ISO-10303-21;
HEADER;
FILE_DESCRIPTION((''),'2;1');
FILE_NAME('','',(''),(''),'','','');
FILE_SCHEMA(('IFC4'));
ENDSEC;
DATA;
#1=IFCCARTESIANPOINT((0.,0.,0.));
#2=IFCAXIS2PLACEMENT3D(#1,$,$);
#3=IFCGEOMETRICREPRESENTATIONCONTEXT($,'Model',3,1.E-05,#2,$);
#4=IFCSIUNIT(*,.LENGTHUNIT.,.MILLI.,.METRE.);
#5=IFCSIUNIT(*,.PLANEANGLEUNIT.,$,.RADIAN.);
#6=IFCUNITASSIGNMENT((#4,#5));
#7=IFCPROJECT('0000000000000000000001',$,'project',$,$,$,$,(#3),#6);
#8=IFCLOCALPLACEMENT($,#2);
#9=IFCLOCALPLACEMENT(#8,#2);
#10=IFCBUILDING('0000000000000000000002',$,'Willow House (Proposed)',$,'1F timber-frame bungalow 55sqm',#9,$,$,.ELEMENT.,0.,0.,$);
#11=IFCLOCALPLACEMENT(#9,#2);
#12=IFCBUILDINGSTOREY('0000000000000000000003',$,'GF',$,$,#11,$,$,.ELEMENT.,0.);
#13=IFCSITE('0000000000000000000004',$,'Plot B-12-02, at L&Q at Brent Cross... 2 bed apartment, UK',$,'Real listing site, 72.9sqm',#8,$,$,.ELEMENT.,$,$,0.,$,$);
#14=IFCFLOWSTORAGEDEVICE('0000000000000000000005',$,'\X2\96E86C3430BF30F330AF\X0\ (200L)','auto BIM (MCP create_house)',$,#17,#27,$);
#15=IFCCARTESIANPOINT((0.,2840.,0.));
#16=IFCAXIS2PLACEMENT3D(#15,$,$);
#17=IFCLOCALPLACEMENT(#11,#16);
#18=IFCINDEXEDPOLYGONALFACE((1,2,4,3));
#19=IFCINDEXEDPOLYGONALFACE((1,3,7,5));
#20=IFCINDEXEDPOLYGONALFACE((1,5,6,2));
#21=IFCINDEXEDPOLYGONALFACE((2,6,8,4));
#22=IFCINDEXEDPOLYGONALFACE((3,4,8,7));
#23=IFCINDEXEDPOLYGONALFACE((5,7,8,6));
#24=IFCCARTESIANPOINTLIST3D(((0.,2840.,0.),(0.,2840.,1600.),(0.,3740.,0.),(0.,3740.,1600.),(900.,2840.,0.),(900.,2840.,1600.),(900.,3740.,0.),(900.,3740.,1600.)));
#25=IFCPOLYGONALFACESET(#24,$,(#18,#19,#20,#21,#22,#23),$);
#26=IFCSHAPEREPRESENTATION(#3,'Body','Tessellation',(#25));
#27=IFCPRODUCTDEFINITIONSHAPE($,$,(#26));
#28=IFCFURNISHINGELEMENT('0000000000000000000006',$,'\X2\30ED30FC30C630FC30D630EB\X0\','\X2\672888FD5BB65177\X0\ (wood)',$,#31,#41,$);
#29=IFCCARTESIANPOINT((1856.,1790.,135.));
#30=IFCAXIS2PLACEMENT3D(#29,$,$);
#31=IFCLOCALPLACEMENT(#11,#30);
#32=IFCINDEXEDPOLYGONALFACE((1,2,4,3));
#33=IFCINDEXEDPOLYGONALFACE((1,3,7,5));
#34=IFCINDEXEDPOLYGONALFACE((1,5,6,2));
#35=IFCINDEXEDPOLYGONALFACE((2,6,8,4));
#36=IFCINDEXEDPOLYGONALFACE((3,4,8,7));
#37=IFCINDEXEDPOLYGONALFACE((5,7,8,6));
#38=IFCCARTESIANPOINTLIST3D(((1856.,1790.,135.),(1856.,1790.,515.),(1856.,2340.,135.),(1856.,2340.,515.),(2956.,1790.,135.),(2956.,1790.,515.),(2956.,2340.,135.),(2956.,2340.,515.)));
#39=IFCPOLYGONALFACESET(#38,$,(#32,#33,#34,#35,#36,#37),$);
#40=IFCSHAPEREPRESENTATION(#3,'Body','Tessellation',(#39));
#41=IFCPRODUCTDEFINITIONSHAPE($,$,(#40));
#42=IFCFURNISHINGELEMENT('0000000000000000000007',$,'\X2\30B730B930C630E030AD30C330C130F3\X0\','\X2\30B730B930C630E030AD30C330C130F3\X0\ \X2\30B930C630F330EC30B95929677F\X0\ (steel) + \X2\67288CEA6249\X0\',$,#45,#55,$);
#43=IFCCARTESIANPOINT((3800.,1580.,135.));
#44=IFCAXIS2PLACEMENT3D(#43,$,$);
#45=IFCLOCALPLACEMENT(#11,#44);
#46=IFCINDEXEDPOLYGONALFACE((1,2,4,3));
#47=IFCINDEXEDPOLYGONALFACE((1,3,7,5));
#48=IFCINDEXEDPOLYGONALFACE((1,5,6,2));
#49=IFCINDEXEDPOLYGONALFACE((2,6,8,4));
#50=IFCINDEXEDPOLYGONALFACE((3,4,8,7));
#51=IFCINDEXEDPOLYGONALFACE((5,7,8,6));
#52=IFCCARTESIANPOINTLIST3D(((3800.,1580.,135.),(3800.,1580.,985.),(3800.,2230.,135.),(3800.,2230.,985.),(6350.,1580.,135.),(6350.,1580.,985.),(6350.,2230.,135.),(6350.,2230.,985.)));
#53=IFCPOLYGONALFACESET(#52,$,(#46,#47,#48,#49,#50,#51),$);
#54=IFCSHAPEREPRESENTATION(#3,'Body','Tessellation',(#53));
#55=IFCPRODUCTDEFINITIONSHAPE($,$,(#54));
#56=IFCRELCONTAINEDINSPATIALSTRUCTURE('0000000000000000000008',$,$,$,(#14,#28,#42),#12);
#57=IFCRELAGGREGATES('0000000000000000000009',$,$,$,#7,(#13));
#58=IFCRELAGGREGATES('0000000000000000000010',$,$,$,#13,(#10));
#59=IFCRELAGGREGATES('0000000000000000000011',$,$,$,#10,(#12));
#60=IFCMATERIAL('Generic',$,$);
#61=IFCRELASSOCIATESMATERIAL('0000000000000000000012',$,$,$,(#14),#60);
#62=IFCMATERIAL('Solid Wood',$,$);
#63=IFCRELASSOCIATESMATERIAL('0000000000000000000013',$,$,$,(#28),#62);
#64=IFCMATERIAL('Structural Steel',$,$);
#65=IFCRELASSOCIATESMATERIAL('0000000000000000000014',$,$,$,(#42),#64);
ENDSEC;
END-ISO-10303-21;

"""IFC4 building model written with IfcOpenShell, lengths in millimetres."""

from ifc_helpers import new_model, si_unit, frame, frame_2d, origin, place, context, project, spatial, rectangle, extrude, material, element, save


model = new_model("IFC4")

# Units and contexts
model_context = context("Model", 3, precision=1e-05, world=origin())
ifc_project = project(units=[si_unit("LENGTHUNIT", "METRE", prefix="MILLI"), si_unit("PLANEANGLEUNIT", "RADIAN")], contexts=[model_context])

# Site, building, storey
site_placement = place(None, origin())
site = spatial("IfcSite", under=ifc_project, at=site_placement, Name="Plot B-12-02, at L&Q at Brent Cross... 2 bed apartment, UK", ObjectType="Real listing site, 72.9sqm", CompositionType="ELEMENT", RefElevation=0.0)
building_placement = place(site_placement, origin())
building = spatial("IfcBuilding", under=site, at=building_placement, Name="Willow House (Proposed)", ObjectType="1F timber-frame bungalow 55sqm", CompositionType="ELEMENT", ElevationOfRefHeight=0.0, ElevationOfTerrain=0.0)
storey_placement = place(building_placement, origin())
storey = spatial("IfcBuildingStorey", under=building, at=storey_placement, Name="GF", CompositionType="ELEMENT", Elevation=0.0)

# Shared definitions
ifc_material_1 = material(Name="Solid Wood")

# Shared definitions
ifc_material_2 = material(Name="Generic")

# Flow storage device
flow_storage_device_placement = place(storey_placement, frame((0.0, 2840.0, 0.0)))
element("IfcFlowStorageDevice", 1, at=flow_storage_device_placement, inside=storey, material=ifc_material_2, Name="雨水タンク (200L)", Description="auto BIM (MCP create_house)", context=model_context, shape_type="SweptSolid", body=[
    extrude(rectangle(XDim=900.0, YDim=900.0, at=frame_2d((450.0, 450.0))), frame((0.0, 2840.0, 0.0)), (0.0, 0.0, 1.0), 1600.0),
])

# Furnishing elements
furnishing_1_placement = place(storey_placement, frame((1856.0, 1790.0, 135.0)))
element("IfcFurnishingElement", 2, at=furnishing_1_placement, inside=storey, material=ifc_material_1, Name="ローテーブル", Description="木製家具 (wood)", context=model_context, shape_type="SweptSolid", body=[
    extrude(rectangle(XDim=1100.0, YDim=550.0, at=frame_2d((550.0, 275.0))), frame((1856.0, 1790.0, 135.0)), (0.0, 0.0, 1.0), 380.0),
])
ifc_material_3 = material(Name="Structural Steel")
furnishing_2_placement = place(storey_placement, frame((3800.0, 1580.0, 135.0)))
element("IfcFurnishingElement", 3, at=furnishing_2_placement, inside=storey, material=ifc_material_3, Name="システムキッチン", Description="システムキッチン ステンレス天板 (steel) + 木質扉", context=model_context, shape_type="SweptSolid", body=[
    extrude(rectangle(XDim=2550.0, YDim=650.0, at=frame_2d((1275.0, 325.0))), frame((3800.0, 1580.0, 135.0)), (0.0, 0.0, 1.0), 850.0),
])

save(model, "model.ifc")
